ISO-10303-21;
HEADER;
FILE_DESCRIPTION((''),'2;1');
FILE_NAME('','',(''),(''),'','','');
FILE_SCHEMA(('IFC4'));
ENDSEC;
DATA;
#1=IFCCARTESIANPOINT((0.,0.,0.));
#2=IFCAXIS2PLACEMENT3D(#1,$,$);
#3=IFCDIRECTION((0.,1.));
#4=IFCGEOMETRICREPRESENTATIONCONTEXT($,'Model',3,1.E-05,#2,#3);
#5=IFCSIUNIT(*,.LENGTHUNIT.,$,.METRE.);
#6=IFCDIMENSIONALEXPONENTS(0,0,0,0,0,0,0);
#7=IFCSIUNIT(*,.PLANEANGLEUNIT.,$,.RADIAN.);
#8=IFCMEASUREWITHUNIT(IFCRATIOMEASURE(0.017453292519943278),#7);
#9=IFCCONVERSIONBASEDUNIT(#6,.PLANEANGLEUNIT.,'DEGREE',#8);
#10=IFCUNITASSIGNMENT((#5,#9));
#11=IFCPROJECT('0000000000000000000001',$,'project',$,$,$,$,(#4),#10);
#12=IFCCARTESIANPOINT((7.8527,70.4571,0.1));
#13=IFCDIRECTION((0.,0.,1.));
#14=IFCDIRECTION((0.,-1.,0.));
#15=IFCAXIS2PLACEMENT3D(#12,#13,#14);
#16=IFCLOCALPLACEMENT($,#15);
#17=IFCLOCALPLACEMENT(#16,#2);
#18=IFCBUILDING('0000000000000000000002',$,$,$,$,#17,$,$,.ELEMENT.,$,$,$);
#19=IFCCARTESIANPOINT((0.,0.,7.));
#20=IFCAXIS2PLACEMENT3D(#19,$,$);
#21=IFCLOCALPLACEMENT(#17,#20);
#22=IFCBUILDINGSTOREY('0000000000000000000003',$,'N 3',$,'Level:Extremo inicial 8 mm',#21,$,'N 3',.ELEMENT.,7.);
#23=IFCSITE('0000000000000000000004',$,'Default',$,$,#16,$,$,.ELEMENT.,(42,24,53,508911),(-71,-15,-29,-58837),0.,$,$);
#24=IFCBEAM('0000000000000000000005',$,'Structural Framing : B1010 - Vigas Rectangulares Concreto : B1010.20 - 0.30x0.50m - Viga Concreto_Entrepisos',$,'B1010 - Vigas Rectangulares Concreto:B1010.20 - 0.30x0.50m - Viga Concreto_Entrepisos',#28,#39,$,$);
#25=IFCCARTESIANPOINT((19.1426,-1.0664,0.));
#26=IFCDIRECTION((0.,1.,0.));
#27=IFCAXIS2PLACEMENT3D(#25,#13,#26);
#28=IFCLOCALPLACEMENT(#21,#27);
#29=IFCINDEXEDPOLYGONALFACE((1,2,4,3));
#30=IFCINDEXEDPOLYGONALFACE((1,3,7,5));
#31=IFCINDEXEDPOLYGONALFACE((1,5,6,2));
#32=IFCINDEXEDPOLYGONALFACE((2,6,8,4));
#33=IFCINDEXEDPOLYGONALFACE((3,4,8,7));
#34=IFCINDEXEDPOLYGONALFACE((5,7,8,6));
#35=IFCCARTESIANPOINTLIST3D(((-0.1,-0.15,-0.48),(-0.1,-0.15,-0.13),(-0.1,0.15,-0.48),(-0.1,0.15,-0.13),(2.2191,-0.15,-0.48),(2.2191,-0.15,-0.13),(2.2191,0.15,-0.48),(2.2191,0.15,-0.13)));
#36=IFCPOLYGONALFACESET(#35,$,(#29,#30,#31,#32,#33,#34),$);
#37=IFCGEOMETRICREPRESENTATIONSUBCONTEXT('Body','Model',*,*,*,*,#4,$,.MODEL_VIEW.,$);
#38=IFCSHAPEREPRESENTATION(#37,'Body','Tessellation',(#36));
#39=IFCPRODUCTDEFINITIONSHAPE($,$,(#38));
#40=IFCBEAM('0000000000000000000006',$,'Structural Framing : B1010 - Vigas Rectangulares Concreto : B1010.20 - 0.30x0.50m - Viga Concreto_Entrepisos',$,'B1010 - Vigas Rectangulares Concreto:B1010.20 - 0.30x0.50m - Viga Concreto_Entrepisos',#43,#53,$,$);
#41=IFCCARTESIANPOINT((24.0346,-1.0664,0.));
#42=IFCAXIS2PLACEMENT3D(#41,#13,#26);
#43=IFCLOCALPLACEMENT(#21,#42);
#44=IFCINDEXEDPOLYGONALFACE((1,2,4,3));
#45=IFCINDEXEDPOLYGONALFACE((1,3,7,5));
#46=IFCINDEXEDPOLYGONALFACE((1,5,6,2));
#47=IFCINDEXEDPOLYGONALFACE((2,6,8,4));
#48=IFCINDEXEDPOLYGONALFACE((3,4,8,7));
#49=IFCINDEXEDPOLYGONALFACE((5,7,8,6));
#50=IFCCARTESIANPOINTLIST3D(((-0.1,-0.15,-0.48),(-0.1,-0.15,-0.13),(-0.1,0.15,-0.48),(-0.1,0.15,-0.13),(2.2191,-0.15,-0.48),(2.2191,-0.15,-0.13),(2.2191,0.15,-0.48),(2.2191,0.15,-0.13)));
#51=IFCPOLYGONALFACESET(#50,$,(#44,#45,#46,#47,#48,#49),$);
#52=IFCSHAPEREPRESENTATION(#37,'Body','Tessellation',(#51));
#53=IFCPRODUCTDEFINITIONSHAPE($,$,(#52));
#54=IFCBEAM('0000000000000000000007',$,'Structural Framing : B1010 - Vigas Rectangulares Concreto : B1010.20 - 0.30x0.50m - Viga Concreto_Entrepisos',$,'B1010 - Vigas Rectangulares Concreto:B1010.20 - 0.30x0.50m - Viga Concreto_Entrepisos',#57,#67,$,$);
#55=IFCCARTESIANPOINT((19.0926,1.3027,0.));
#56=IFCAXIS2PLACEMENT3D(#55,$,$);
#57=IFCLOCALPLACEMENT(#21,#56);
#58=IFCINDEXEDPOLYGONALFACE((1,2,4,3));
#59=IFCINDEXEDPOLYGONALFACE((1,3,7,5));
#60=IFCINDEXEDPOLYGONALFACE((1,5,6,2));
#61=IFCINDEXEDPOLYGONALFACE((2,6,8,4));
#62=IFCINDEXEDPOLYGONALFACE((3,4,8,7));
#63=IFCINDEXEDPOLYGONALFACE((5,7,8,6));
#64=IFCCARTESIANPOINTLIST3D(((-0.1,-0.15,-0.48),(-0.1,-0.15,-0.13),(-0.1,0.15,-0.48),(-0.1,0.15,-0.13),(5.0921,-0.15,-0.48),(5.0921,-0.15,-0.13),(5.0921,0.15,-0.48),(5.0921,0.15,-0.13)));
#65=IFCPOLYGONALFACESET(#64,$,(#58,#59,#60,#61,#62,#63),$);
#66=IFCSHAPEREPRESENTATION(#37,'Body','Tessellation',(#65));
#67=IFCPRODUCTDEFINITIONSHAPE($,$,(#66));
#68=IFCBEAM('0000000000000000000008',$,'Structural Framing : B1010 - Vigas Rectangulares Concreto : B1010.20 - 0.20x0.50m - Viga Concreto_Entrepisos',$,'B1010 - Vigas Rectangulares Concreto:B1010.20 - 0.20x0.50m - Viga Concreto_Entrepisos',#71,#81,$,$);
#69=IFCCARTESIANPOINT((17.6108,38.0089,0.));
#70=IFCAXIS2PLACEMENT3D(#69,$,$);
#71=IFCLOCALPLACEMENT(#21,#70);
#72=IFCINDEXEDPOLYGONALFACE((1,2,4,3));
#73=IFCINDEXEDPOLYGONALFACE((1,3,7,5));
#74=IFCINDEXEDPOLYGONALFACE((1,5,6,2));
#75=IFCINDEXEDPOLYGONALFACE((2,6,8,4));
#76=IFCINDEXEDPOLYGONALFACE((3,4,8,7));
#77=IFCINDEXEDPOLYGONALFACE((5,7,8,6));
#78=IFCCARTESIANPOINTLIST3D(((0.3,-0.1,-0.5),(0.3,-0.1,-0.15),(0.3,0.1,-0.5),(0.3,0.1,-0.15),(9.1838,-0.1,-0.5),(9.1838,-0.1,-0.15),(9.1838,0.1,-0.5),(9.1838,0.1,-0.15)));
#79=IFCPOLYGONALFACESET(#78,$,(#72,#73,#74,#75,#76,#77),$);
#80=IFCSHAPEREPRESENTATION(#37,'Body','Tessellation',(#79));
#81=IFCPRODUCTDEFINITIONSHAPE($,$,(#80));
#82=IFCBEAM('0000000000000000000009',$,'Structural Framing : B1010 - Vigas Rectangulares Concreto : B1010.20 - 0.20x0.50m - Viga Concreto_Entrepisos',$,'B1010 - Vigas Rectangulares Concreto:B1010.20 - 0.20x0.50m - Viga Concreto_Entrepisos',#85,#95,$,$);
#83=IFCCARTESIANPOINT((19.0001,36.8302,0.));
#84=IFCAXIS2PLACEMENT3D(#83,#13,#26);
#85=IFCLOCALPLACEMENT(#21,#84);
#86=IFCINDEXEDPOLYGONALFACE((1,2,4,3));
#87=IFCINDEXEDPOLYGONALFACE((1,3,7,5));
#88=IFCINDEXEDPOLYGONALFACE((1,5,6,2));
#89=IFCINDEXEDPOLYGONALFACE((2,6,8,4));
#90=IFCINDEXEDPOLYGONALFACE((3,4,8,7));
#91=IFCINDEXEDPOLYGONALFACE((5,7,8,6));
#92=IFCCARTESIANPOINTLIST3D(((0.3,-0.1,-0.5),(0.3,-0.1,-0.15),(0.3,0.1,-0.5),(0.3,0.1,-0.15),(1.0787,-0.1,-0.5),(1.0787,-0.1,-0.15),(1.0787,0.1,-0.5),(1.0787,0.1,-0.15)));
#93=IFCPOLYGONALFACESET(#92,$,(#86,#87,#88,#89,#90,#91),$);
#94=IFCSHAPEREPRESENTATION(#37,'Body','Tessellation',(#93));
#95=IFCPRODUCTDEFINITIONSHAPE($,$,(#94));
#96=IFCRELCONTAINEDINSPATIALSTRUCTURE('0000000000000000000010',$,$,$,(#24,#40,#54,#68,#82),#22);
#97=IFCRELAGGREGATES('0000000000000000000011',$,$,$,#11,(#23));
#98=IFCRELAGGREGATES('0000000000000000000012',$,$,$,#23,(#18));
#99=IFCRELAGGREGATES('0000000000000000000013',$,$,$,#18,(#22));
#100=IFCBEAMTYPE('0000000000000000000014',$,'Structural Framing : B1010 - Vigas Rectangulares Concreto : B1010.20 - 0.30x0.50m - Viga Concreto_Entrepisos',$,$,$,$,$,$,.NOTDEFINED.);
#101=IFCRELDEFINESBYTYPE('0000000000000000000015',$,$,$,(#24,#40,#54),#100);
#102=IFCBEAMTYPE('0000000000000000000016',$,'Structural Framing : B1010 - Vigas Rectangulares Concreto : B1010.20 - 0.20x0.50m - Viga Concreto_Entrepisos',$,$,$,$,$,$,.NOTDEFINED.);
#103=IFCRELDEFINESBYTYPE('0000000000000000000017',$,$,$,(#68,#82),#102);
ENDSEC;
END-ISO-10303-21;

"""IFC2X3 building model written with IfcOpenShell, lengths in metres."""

from ifc_helpers import new_model, entity, si_unit, converted_unit, direction, frame, frame_2d, origin, place, context, subcontext, project, spatial, rectangle, extrude, type_object, element, save


model = new_model("IFC2X3")

# Units and contexts
model_context = context("Model", 3, precision=1e-05, world=origin(), true_north=direction((0.0, 1.0)))
body_context = subcontext(model_context, "Body", "Model", "MODEL_VIEW")
ifc_project = project(units=[si_unit("LENGTHUNIT", "METRE"), converted_unit("PLANEANGLEUNIT", "DEGREE", entity("IfcRatioMeasure", 0.017453292519943278), si_unit("PLANEANGLEUNIT", "RADIAN"), dimensions=[0, 0, 0, 0, 0, 0, 0])], contexts=[model_context])

# Site, building, storey
site_placement = place(None, frame((7.8527, 70.4571, 0.1), z_axis=(0.0, 0.0, 1.0), x_axis=(0.0, -1.0, 0.0)))
site = spatial("IfcSite", under=ifc_project, at=site_placement, Name="Default", CompositionType="ELEMENT", RefLatitude=(42, 24, 53, 508911), RefLongitude=(-71, -15, -29, -58837), RefElevation=0.0)
building_placement = place(site_placement, origin())
building = spatial("IfcBuilding", under=site, at=building_placement, CompositionType="ELEMENT")
storey_placement = place(building_placement, frame((0.0, 0.0, 7.0)))
storey = spatial("IfcBuildingStorey", under=building, at=storey_placement, Name="N 3", ObjectType="Level:Extremo inicial 8 mm", LongName="N 3", CompositionType="ELEMENT", Elevation=7.0)

# Beams
beam_type_1 = type_object("IfcBeamType", Name="Structural Framing : B1010 - Vigas Rectangulares Concreto : B1010.20 - 0.30x0.50m - Viga Concreto_Entrepisos", PredefinedType="NOTDEFINED")
beam_1_placement = place(storey_placement, frame((19.1426, -1.0664, 0.0), z_axis=(0.0, 0.0, 1.0), x_axis=(0.0, 1.0, 0.0)))
element("IfcBeam", 1, at=beam_1_placement, inside=storey, type_object=beam_type_1, Name="Structural Framing : B1010 - Vigas Rectangulares Concreto : B1010.20 - 0.30x0.50m - Viga Concreto_Entrepisos", ObjectType="B1010 - Vigas Rectangulares Concreto:B1010.20 - 0.30x0.50m - Viga Concreto_Entrepisos", context=body_context, shape_type="SweptSolid", body=[
    extrude(rectangle(XDim=0.35, YDim=0.3, at=frame_2d((0.0, 0.0), x_axis=(1.0, 0.0))), frame((-0.1, 0.0, -0.305), z_axis=(1.0, 0.0, 0.0), x_axis=(0.0, 0.0, -1.0)), (0.0, 0.0, 1.0), 2.3191),
])
beam_2_placement = place(storey_placement, frame((24.0346, -1.0664, 0.0), z_axis=(0.0, 0.0, 1.0), x_axis=(0.0, 1.0, 0.0)))
element("IfcBeam", 2, at=beam_2_placement, inside=storey, type_object=beam_type_1, Name="Structural Framing : B1010 - Vigas Rectangulares Concreto : B1010.20 - 0.30x0.50m - Viga Concreto_Entrepisos", ObjectType="B1010 - Vigas Rectangulares Concreto:B1010.20 - 0.30x0.50m - Viga Concreto_Entrepisos", context=body_context, shape_type="SweptSolid", body=[
    extrude(rectangle(XDim=0.35, YDim=0.3, at=frame_2d((0.0, 0.0), x_axis=(1.0, 0.0))), frame((-0.1, 0.0, -0.305), z_axis=(1.0, 0.0, 0.0), x_axis=(0.0, 0.0, -1.0)), (0.0, 0.0, 1.0), 2.3191),
])
beam_3_placement = place(storey_placement, frame((19.0926, 1.3027, 0.0)))
element("IfcBeam", 3, at=beam_3_placement, inside=storey, type_object=beam_type_1, Name="Structural Framing : B1010 - Vigas Rectangulares Concreto : B1010.20 - 0.30x0.50m - Viga Concreto_Entrepisos", ObjectType="B1010 - Vigas Rectangulares Concreto:B1010.20 - 0.30x0.50m - Viga Concreto_Entrepisos", context=body_context, shape_type="SweptSolid", body=[
    extrude(rectangle(XDim=0.35, YDim=0.3, at=frame_2d((0.0, 0.0), x_axis=(1.0, 0.0))), frame((-0.1, 0.0, -0.305), z_axis=(1.0, 0.0, 0.0), x_axis=(0.0, 0.0, -1.0)), (0.0, 0.0, 1.0), 5.1921),
])
beam_type_2 = type_object("IfcBeamType", Name="Structural Framing : B1010 - Vigas Rectangulares Concreto : B1010.20 - 0.20x0.50m - Viga Concreto_Entrepisos", PredefinedType="NOTDEFINED")
beam_4_placement = place(storey_placement, frame((17.6108, 38.0089, 0.0)))
element("IfcBeam", 4, at=beam_4_placement, inside=storey, type_object=beam_type_2, Name="Structural Framing : B1010 - Vigas Rectangulares Concreto : B1010.20 - 0.20x0.50m - Viga Concreto_Entrepisos", ObjectType="B1010 - Vigas Rectangulares Concreto:B1010.20 - 0.20x0.50m - Viga Concreto_Entrepisos", context=body_context, shape_type="SweptSolid", body=[
    extrude(rectangle(XDim=0.35, YDim=0.2, at=frame_2d((0.0, 0.0), x_axis=(1.0, 0.0))), frame((0.3, 0.0, -0.325), z_axis=(1.0, 0.0, 0.0), x_axis=(0.0, 0.0, -1.0)), (0.0, 0.0, 1.0), 8.8838),
])
beam_5_placement = place(storey_placement, frame((19.0001, 36.8302, 0.0), z_axis=(0.0, 0.0, 1.0), x_axis=(0.0, 1.0, 0.0)))
element("IfcBeam", 5, at=beam_5_placement, inside=storey, type_object=beam_type_2, Name="Structural Framing : B1010 - Vigas Rectangulares Concreto : B1010.20 - 0.20x0.50m - Viga Concreto_Entrepisos", ObjectType="B1010 - Vigas Rectangulares Concreto:B1010.20 - 0.20x0.50m - Viga Concreto_Entrepisos", context=body_context, shape_type="SweptSolid", body=[
    extrude(rectangle(XDim=0.35, YDim=0.2, at=frame_2d((0.0, 0.0), x_axis=(1.0, 0.0))), frame((0.3, 0.0, -0.325), z_axis=(1.0, 0.0, 0.0), x_axis=(0.0, 0.0, -1.0)), (0.0, 0.0, 1.0), 0.7787),
])

save(model, "model.ifc")
